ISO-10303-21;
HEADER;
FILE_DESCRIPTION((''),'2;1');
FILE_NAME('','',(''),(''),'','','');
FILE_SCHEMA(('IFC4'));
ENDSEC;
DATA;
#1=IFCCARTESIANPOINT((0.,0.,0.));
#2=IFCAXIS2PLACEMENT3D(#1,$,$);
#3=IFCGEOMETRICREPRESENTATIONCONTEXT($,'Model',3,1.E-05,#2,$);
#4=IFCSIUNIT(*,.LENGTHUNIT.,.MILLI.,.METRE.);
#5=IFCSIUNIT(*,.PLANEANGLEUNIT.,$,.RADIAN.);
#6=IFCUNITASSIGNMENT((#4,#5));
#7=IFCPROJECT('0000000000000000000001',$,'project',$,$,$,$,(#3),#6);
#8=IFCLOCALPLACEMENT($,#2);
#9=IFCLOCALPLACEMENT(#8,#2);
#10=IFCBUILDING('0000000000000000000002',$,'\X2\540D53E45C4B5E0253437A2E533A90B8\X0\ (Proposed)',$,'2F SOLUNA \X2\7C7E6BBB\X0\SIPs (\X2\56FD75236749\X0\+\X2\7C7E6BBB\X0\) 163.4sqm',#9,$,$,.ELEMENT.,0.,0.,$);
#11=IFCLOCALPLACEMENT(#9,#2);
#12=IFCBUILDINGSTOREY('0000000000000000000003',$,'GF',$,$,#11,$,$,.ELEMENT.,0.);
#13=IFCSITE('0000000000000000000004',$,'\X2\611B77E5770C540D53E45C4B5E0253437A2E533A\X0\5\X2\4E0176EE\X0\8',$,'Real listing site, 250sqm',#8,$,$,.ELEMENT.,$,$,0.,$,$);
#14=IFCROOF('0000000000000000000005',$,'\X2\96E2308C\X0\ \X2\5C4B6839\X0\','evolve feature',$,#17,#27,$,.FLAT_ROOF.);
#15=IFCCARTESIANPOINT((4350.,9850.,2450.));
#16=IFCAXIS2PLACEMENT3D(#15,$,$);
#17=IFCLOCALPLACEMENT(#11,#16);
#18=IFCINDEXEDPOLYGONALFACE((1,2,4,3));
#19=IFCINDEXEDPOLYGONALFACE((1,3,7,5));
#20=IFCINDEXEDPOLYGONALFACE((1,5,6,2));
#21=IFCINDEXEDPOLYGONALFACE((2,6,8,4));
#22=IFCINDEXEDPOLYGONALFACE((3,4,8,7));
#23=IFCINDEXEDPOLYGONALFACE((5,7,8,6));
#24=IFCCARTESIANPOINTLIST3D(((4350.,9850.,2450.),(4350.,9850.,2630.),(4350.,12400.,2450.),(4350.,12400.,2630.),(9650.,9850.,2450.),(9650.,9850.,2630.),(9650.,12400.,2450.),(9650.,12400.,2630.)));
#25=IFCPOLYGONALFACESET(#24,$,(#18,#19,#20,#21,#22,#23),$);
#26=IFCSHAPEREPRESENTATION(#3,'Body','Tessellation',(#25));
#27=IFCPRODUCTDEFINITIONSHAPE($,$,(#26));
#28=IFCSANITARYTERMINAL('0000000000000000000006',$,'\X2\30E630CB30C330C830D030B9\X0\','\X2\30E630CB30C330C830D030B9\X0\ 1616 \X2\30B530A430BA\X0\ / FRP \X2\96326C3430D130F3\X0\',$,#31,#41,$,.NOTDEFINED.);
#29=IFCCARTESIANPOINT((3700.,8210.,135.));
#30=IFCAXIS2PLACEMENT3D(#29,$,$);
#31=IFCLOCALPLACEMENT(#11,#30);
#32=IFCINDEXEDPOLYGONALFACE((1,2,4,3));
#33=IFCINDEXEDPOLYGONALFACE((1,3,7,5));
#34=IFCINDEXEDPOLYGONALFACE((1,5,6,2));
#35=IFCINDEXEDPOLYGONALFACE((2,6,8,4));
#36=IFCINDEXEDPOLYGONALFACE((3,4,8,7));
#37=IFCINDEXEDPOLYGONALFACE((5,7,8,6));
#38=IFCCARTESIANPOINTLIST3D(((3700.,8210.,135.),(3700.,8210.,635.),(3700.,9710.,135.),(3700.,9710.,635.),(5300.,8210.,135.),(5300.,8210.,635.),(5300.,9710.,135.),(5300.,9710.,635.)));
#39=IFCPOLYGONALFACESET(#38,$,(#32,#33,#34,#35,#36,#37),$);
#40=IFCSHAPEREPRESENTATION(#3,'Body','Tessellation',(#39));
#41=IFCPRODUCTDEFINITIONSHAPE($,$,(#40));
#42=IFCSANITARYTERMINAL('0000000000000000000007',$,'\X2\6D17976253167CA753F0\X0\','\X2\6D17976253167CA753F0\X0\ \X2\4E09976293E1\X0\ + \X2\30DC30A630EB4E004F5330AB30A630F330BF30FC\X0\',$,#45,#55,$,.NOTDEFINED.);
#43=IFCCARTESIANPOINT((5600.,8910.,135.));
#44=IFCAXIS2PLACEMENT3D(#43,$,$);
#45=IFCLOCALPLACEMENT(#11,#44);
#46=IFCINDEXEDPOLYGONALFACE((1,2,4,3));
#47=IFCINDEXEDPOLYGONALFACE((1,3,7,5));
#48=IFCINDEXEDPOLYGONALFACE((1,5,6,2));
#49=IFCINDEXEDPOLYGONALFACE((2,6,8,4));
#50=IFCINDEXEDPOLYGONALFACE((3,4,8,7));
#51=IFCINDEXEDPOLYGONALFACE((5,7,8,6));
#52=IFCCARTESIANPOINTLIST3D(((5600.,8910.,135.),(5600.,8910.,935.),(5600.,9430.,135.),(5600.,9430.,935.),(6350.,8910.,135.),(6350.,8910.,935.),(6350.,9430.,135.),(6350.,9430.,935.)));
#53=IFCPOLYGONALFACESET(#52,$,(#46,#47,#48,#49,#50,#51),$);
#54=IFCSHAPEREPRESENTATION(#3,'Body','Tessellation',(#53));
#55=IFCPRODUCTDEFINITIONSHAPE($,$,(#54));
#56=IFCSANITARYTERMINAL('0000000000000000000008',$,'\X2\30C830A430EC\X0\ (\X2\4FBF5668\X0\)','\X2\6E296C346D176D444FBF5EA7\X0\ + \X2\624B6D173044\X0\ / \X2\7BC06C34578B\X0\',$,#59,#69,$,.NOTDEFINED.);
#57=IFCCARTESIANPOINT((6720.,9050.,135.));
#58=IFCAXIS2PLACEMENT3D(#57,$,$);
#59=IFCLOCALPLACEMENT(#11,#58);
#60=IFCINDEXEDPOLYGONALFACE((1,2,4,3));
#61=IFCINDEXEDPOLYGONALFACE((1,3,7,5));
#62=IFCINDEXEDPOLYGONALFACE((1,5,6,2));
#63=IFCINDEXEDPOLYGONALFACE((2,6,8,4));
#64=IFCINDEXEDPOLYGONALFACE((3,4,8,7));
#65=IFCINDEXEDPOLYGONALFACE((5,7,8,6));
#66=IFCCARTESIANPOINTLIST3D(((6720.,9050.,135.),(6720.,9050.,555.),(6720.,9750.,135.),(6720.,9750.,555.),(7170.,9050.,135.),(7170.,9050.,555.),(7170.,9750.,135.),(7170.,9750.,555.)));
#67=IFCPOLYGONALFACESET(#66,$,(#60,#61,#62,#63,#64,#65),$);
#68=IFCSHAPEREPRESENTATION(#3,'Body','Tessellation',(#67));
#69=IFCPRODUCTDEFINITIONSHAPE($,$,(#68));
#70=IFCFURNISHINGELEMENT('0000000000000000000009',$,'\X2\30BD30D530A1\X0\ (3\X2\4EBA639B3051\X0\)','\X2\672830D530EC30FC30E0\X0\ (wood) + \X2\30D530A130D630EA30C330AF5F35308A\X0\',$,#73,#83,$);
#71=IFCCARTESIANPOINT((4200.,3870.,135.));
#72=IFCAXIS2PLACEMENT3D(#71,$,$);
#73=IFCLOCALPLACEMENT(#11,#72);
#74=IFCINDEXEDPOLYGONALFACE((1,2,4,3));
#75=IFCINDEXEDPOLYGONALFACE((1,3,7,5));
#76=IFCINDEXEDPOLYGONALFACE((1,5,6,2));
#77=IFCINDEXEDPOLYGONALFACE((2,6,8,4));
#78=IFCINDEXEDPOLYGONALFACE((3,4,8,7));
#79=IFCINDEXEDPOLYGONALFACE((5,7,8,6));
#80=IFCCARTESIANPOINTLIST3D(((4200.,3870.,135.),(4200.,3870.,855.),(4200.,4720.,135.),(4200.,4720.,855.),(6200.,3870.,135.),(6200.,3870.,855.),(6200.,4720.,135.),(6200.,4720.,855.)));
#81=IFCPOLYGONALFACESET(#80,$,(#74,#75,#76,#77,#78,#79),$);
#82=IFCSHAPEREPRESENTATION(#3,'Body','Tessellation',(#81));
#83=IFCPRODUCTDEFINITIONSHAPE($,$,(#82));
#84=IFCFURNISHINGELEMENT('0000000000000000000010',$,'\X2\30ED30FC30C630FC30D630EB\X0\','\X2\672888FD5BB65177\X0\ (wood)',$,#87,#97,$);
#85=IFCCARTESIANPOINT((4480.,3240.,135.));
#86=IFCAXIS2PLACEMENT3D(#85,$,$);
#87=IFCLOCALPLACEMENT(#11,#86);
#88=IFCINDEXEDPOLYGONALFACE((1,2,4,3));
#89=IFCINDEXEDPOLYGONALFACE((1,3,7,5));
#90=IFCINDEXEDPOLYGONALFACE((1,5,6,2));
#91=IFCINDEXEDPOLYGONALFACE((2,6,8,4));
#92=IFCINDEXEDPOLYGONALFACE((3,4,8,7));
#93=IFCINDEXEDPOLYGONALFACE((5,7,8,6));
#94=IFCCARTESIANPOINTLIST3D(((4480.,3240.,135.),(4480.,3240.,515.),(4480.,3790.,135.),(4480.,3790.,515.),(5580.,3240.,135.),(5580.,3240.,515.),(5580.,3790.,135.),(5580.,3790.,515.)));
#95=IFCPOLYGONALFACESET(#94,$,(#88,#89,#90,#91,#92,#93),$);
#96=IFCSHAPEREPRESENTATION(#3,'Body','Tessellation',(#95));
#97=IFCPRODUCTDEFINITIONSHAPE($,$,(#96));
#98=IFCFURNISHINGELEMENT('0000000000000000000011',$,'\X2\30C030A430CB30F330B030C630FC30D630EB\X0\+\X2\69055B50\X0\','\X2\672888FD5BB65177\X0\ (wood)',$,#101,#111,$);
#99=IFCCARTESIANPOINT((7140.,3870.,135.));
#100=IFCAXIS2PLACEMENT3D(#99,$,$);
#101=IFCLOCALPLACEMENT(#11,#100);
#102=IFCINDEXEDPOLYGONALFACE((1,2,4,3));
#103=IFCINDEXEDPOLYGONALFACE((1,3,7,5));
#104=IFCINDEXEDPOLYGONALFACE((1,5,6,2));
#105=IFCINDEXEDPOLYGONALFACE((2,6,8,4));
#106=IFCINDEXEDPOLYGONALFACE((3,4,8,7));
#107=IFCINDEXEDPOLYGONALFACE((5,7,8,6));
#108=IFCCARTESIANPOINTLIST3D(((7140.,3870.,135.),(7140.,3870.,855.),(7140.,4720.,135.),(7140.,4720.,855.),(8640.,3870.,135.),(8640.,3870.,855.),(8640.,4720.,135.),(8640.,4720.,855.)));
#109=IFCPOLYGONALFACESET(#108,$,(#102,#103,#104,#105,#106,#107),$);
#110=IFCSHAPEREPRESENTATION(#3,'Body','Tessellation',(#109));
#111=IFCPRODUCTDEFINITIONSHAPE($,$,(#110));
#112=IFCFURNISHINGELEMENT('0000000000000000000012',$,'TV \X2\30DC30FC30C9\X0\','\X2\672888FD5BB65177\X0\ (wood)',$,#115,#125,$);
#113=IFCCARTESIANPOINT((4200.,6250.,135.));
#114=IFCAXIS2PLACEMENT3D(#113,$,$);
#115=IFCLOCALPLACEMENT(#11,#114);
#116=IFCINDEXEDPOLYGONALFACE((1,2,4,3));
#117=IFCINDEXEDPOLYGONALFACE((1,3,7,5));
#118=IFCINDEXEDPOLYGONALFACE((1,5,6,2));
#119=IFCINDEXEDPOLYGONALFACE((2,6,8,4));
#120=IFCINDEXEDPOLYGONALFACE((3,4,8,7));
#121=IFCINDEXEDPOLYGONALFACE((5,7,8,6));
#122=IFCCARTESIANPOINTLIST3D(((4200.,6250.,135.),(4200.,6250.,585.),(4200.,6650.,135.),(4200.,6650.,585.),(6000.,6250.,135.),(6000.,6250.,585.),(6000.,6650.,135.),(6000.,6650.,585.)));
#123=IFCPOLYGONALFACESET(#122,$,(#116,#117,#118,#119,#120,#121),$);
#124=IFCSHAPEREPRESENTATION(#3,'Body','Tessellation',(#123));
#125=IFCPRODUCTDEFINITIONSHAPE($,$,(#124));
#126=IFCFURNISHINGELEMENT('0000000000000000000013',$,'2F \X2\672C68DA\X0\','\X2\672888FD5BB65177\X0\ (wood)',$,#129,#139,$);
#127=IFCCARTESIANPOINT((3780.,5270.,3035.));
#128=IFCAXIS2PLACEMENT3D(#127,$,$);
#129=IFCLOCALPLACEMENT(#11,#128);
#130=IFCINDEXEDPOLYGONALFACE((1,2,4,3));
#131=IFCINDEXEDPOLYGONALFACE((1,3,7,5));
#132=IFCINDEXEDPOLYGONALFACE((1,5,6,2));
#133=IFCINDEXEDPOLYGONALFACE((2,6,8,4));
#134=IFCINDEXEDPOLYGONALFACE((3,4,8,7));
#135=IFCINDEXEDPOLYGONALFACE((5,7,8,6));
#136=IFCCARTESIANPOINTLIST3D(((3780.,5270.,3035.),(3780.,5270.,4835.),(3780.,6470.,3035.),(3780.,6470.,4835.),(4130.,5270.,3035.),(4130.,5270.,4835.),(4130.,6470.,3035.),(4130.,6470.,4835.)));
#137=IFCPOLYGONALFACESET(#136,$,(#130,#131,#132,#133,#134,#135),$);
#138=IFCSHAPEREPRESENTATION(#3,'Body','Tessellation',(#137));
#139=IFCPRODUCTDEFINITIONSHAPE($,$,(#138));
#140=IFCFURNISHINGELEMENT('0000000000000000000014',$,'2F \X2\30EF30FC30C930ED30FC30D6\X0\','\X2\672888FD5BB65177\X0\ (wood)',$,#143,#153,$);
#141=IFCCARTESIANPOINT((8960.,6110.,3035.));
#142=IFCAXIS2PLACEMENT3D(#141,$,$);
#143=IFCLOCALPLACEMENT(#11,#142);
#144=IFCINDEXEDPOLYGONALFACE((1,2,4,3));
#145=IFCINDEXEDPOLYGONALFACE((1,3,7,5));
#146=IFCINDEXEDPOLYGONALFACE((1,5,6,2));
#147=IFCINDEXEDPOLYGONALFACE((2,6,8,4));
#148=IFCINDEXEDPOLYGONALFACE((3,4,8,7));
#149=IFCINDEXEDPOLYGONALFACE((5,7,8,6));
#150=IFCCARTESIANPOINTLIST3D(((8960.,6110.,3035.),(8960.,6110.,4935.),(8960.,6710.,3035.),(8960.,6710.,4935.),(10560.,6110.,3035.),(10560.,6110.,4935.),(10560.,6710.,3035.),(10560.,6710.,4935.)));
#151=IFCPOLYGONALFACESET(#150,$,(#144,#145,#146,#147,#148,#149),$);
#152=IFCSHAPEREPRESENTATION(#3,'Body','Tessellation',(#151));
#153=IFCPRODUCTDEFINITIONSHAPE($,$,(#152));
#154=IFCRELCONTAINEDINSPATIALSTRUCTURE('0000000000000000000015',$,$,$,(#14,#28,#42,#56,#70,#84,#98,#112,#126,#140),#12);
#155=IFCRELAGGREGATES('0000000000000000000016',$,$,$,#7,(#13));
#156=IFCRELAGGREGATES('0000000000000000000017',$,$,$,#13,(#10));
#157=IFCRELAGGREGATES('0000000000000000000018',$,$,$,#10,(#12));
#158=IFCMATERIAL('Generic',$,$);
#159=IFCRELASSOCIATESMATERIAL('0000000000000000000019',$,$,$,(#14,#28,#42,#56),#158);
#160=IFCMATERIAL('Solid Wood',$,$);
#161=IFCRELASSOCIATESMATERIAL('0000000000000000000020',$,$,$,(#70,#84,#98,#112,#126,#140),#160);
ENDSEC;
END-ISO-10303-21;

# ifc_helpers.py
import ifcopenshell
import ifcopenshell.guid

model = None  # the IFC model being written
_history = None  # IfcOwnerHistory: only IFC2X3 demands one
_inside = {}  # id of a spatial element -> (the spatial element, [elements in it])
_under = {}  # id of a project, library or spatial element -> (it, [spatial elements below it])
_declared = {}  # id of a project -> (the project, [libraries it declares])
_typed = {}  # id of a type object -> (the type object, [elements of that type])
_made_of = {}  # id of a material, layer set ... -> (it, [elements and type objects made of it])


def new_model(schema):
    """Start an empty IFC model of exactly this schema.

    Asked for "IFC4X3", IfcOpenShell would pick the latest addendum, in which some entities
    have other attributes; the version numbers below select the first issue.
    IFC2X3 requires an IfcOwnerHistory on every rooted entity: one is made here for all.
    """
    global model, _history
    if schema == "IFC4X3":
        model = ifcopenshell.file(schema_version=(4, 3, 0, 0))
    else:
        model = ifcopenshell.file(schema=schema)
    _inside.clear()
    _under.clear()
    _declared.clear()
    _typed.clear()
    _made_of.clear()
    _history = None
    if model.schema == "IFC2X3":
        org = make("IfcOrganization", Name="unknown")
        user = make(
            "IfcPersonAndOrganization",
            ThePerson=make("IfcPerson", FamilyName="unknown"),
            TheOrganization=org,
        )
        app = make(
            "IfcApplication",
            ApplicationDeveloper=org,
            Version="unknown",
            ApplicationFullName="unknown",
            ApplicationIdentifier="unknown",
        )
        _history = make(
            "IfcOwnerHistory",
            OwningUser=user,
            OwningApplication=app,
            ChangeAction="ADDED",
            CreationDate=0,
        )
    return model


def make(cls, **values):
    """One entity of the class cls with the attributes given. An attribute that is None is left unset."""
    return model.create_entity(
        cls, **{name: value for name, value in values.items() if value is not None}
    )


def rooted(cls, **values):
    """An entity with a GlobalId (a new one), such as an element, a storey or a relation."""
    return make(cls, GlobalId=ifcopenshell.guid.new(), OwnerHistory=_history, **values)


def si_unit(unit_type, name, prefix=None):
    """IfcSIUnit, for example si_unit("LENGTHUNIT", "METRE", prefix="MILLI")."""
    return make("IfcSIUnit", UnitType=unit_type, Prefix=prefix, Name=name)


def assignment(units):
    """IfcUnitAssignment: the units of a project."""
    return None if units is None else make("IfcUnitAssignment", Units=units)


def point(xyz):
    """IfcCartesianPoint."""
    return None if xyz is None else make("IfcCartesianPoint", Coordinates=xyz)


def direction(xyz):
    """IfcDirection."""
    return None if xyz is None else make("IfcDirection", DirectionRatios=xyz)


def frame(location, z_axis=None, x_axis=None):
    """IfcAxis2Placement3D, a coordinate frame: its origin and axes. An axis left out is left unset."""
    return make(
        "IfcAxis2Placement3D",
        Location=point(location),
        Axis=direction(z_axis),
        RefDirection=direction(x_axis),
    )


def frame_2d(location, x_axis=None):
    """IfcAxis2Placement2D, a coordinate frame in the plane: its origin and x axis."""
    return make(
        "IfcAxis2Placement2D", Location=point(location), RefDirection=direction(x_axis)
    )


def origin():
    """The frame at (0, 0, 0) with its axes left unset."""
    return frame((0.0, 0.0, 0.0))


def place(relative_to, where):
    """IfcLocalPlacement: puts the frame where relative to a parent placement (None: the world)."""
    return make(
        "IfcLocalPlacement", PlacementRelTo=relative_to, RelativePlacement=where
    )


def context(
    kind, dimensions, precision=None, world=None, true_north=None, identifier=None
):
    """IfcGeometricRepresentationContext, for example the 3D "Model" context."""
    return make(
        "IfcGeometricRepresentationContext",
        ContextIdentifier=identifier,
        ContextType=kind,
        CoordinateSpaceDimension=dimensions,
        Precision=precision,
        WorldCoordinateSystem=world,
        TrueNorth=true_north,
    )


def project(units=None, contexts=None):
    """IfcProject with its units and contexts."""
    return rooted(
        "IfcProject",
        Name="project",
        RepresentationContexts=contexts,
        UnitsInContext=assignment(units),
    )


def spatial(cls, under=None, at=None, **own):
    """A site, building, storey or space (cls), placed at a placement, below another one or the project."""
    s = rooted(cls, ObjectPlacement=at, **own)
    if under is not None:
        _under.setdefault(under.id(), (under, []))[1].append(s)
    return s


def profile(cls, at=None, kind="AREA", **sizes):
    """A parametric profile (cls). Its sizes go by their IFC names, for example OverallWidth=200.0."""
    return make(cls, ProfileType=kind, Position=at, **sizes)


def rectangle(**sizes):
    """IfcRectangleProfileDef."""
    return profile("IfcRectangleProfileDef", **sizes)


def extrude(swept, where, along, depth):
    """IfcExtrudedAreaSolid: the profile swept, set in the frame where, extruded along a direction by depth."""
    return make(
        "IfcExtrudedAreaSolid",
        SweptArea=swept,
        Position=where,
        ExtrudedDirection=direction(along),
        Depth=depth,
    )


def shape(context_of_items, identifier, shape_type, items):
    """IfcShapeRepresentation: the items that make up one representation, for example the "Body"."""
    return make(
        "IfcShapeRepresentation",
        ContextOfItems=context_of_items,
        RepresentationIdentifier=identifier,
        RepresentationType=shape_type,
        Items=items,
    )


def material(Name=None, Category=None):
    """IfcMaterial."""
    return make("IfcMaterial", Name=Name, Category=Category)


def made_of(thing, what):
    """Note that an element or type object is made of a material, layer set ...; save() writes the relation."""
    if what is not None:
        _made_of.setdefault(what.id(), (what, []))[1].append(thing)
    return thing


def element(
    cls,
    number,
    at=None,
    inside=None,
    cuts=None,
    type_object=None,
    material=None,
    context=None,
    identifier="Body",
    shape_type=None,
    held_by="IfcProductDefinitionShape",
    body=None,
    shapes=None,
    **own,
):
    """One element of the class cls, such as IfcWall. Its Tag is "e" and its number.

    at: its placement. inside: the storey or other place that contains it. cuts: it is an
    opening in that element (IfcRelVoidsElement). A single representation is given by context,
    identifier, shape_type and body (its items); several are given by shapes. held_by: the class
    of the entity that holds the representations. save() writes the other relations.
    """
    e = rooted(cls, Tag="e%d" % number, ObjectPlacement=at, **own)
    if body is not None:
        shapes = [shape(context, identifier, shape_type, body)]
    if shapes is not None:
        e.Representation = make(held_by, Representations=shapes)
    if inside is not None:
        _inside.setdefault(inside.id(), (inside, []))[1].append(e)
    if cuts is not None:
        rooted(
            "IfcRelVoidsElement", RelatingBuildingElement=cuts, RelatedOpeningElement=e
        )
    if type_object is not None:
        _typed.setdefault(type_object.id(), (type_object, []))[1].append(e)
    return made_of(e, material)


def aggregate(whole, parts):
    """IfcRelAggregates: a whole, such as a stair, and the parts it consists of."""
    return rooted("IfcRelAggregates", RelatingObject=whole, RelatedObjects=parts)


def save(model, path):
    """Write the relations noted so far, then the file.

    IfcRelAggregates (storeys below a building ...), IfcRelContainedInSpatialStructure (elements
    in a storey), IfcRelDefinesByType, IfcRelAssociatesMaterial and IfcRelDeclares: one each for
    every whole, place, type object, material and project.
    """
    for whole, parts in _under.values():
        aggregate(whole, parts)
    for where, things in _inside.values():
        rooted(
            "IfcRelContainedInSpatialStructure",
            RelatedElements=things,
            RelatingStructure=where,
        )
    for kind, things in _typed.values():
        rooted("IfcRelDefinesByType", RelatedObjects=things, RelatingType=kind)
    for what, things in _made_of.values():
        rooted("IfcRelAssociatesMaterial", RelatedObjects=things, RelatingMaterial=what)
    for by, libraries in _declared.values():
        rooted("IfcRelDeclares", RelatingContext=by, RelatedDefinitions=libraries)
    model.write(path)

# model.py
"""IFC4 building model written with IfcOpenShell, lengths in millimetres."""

from ifc_helpers import new_model, si_unit, frame, frame_2d, origin, place, context, project, spatial, rectangle, extrude, material, element, save


model = new_model("IFC4")

# Units and contexts
model_context = context("Model", 3, precision=1e-05, world=origin())
ifc_project = project(units=[si_unit("LENGTHUNIT", "METRE", prefix="MILLI"), si_unit("PLANEANGLEUNIT", "RADIAN")], contexts=[model_context])

# Site, building, storey
site_placement = place(None, origin())
site = spatial("IfcSite", under=ifc_project, at=site_placement, Name="愛知県名古屋市千種区5丁目8", ObjectType="Real listing site, 250sqm", CompositionType="ELEMENT", RefElevation=0.0)
building_placement = place(site_placement, origin())
building = spatial("IfcBuilding", under=site, at=building_placement, Name="名古屋市千種区邸 (Proposed)", ObjectType="2F SOLUNA 籾殻SIPs (国産杉+籾殻) 163.4sqm", CompositionType="ELEMENT", ElevationOfRefHeight=0.0, ElevationOfTerrain=0.0)
storey_placement = place(building_placement, origin())
storey = spatial("IfcBuildingStorey", under=building, at=storey_placement, Name="GF", CompositionType="ELEMENT", Elevation=0.0)

# Shared definitions
ifc_material_1 = material(Name="Generic")

# Shared definitions
ifc_material_2 = material(Name="Solid Wood")

# Roof
roof_placement = place(storey_placement, frame((4350.0, 9850.0, 2450.0)))
element("IfcRoof", 1, at=roof_placement, inside=storey, material=ifc_material_1, Name="離れ 屋根", Description="evolve feature", PredefinedType="FLAT_ROOF", context=model_context, shape_type="SweptSolid", body=[
    extrude(rectangle(XDim=5300.0, YDim=2550.0, at=frame_2d((2650.0, 1275.0))), frame((4350.0, 9850.0, 2450.0)), (0.0, 0.0, 1.0), 180.0),
])

# Sanitary terminals
sanitary_terminal_1_placement = place(storey_placement, frame((3700.0, 8210.0, 135.0)))
element("IfcSanitaryTerminal", 2, at=sanitary_terminal_1_placement, inside=storey, material=ifc_material_1, Name="ユニットバス", Description="ユニットバス 1616 サイズ / FRP 防水パン", PredefinedType="NOTDEFINED", context=model_context, shape_type="SweptSolid", body=[
    extrude(rectangle(XDim=1600.0, YDim=1500.0, at=frame_2d((800.0, 750.0))), frame((3700.0, 8210.0, 135.0)), (0.0, 0.0, 1.0), 500.0),
])
sanitary_terminal_2_placement = place(storey_placement, frame((5600.0, 8910.0, 135.0)))
element("IfcSanitaryTerminal", 3, at=sanitary_terminal_2_placement, inside=storey, material=ifc_material_1, Name="洗面化粧台", Description="洗面化粧台 三面鏡 + ボウル一体カウンター", PredefinedType="NOTDEFINED", context=model_context, shape_type="SweptSolid", body=[
    extrude(rectangle(XDim=750.0, YDim=520.0, at=frame_2d((375.0, 260.0))), frame((5600.0, 8910.0, 135.0)), (0.0, 0.0, 1.0), 800.0),
])
sanitary_terminal_3_placement = place(storey_placement, frame((6720.0, 9050.0, 135.0)))
element("IfcSanitaryTerminal", 4, at=sanitary_terminal_3_placement, inside=storey, material=ifc_material_1, Name="トイレ (便器)", Description="温水洗浄便座 + 手洗い / 節水型", PredefinedType="NOTDEFINED", context=model_context, shape_type="SweptSolid", body=[
    extrude(rectangle(XDim=450.0, YDim=700.0, at=frame_2d((225.0, 350.0))), frame((6720.0, 9050.0, 135.0)), (0.0, 0.0, 1.0), 420.0),
])

# Furnishing elements
furnishing_1_placement = place(storey_placement, frame((4200.0, 3870.0, 135.0)))
element("IfcFurnishingElement", 5, at=furnishing_1_placement, inside=storey, material=ifc_material_2, Name="ソファ (3人掛け)", Description="木フレーム (wood) + ファブリック張り", context=model_context, shape_type="SweptSolid", body=[
    extrude(rectangle(XDim=2000.0, YDim=850.0, at=frame_2d((1000.0, 425.0))), frame((4200.0, 3870.0, 135.0)), (0.0, 0.0, 1.0), 720.0),
])
furnishing_2_placement = place(storey_placement, frame((4480.0, 3240.0, 135.0)))
element("IfcFurnishingElement", 6, at=furnishing_2_placement, inside=storey, material=ifc_material_2, Name="ローテーブル", Description="木製家具 (wood)", context=model_context, shape_type="SweptSolid", body=[
    extrude(rectangle(XDim=1100.0, YDim=550.0, at=frame_2d((550.0, 275.0))), frame((4480.0, 3240.0, 135.0)), (0.0, 0.0, 1.0), 380.0),
])
furnishing_3_placement = place(storey_placement, frame((7140.0, 3870.0, 135.0)))
element("IfcFurnishingElement", 7, at=furnishing_3_placement, inside=storey, material=ifc_material_2, Name="ダイニングテーブル+椅子", Description="木製家具 (wood)", context=model_context, shape_type="SweptSolid", body=[
    extrude(rectangle(XDim=1500.0, YDim=850.0, at=frame_2d((750.0, 425.0))), frame((7140.0, 3870.0, 135.0)), (0.0, 0.0, 1.0), 720.0),
])
furnishing_4_placement = place(storey_placement, frame((4200.0, 6250.0, 135.0)))
element("IfcFurnishingElement", 8, at=furnishing_4_placement, inside=storey, material=ifc_material_2, Name="TV ボード", Description="木製家具 (wood)", context=model_context, shape_type="SweptSolid", body=[
    extrude(rectangle(XDim=1800.0, YDim=400.0, at=frame_2d((900.0, 200.0))), frame((4200.0, 6250.0, 135.0)), (0.0, 0.0, 1.0), 450.0),
])
furnishing_5_placement = place(storey_placement, frame((3780.0, 5270.0, 3035.0)))
element("IfcFurnishingElement", 9, at=furnishing_5_placement, inside=storey, material=ifc_material_2, Name="2F 本棚", Description="木製家具 (wood)", context=model_context, shape_type="SweptSolid", body=[
    extrude(rectangle(XDim=350.0, YDim=1200.0, at=frame_2d((175.0, 600.0))), frame((3780.0, 5270.0, 3035.0)), (0.0, 0.0, 1.0), 1800.0),
])
furnishing_6_placement = place(storey_placement, frame((8960.0, 6110.0, 3035.0)))
element("IfcFurnishingElement", 10, at=furnishing_6_placement, inside=storey, material=ifc_material_2, Name="2F ワードローブ", Description="木製家具 (wood)", context=model_context, shape_type="SweptSolid", body=[
    extrude(rectangle(XDim=1600.0, YDim=600.0, at=frame_2d((800.0, 300.0))), frame((8960.0, 6110.0, 3035.0)), (0.0, 0.0, 1.0), 1900.0),
])

save(model, "model.ifc")
